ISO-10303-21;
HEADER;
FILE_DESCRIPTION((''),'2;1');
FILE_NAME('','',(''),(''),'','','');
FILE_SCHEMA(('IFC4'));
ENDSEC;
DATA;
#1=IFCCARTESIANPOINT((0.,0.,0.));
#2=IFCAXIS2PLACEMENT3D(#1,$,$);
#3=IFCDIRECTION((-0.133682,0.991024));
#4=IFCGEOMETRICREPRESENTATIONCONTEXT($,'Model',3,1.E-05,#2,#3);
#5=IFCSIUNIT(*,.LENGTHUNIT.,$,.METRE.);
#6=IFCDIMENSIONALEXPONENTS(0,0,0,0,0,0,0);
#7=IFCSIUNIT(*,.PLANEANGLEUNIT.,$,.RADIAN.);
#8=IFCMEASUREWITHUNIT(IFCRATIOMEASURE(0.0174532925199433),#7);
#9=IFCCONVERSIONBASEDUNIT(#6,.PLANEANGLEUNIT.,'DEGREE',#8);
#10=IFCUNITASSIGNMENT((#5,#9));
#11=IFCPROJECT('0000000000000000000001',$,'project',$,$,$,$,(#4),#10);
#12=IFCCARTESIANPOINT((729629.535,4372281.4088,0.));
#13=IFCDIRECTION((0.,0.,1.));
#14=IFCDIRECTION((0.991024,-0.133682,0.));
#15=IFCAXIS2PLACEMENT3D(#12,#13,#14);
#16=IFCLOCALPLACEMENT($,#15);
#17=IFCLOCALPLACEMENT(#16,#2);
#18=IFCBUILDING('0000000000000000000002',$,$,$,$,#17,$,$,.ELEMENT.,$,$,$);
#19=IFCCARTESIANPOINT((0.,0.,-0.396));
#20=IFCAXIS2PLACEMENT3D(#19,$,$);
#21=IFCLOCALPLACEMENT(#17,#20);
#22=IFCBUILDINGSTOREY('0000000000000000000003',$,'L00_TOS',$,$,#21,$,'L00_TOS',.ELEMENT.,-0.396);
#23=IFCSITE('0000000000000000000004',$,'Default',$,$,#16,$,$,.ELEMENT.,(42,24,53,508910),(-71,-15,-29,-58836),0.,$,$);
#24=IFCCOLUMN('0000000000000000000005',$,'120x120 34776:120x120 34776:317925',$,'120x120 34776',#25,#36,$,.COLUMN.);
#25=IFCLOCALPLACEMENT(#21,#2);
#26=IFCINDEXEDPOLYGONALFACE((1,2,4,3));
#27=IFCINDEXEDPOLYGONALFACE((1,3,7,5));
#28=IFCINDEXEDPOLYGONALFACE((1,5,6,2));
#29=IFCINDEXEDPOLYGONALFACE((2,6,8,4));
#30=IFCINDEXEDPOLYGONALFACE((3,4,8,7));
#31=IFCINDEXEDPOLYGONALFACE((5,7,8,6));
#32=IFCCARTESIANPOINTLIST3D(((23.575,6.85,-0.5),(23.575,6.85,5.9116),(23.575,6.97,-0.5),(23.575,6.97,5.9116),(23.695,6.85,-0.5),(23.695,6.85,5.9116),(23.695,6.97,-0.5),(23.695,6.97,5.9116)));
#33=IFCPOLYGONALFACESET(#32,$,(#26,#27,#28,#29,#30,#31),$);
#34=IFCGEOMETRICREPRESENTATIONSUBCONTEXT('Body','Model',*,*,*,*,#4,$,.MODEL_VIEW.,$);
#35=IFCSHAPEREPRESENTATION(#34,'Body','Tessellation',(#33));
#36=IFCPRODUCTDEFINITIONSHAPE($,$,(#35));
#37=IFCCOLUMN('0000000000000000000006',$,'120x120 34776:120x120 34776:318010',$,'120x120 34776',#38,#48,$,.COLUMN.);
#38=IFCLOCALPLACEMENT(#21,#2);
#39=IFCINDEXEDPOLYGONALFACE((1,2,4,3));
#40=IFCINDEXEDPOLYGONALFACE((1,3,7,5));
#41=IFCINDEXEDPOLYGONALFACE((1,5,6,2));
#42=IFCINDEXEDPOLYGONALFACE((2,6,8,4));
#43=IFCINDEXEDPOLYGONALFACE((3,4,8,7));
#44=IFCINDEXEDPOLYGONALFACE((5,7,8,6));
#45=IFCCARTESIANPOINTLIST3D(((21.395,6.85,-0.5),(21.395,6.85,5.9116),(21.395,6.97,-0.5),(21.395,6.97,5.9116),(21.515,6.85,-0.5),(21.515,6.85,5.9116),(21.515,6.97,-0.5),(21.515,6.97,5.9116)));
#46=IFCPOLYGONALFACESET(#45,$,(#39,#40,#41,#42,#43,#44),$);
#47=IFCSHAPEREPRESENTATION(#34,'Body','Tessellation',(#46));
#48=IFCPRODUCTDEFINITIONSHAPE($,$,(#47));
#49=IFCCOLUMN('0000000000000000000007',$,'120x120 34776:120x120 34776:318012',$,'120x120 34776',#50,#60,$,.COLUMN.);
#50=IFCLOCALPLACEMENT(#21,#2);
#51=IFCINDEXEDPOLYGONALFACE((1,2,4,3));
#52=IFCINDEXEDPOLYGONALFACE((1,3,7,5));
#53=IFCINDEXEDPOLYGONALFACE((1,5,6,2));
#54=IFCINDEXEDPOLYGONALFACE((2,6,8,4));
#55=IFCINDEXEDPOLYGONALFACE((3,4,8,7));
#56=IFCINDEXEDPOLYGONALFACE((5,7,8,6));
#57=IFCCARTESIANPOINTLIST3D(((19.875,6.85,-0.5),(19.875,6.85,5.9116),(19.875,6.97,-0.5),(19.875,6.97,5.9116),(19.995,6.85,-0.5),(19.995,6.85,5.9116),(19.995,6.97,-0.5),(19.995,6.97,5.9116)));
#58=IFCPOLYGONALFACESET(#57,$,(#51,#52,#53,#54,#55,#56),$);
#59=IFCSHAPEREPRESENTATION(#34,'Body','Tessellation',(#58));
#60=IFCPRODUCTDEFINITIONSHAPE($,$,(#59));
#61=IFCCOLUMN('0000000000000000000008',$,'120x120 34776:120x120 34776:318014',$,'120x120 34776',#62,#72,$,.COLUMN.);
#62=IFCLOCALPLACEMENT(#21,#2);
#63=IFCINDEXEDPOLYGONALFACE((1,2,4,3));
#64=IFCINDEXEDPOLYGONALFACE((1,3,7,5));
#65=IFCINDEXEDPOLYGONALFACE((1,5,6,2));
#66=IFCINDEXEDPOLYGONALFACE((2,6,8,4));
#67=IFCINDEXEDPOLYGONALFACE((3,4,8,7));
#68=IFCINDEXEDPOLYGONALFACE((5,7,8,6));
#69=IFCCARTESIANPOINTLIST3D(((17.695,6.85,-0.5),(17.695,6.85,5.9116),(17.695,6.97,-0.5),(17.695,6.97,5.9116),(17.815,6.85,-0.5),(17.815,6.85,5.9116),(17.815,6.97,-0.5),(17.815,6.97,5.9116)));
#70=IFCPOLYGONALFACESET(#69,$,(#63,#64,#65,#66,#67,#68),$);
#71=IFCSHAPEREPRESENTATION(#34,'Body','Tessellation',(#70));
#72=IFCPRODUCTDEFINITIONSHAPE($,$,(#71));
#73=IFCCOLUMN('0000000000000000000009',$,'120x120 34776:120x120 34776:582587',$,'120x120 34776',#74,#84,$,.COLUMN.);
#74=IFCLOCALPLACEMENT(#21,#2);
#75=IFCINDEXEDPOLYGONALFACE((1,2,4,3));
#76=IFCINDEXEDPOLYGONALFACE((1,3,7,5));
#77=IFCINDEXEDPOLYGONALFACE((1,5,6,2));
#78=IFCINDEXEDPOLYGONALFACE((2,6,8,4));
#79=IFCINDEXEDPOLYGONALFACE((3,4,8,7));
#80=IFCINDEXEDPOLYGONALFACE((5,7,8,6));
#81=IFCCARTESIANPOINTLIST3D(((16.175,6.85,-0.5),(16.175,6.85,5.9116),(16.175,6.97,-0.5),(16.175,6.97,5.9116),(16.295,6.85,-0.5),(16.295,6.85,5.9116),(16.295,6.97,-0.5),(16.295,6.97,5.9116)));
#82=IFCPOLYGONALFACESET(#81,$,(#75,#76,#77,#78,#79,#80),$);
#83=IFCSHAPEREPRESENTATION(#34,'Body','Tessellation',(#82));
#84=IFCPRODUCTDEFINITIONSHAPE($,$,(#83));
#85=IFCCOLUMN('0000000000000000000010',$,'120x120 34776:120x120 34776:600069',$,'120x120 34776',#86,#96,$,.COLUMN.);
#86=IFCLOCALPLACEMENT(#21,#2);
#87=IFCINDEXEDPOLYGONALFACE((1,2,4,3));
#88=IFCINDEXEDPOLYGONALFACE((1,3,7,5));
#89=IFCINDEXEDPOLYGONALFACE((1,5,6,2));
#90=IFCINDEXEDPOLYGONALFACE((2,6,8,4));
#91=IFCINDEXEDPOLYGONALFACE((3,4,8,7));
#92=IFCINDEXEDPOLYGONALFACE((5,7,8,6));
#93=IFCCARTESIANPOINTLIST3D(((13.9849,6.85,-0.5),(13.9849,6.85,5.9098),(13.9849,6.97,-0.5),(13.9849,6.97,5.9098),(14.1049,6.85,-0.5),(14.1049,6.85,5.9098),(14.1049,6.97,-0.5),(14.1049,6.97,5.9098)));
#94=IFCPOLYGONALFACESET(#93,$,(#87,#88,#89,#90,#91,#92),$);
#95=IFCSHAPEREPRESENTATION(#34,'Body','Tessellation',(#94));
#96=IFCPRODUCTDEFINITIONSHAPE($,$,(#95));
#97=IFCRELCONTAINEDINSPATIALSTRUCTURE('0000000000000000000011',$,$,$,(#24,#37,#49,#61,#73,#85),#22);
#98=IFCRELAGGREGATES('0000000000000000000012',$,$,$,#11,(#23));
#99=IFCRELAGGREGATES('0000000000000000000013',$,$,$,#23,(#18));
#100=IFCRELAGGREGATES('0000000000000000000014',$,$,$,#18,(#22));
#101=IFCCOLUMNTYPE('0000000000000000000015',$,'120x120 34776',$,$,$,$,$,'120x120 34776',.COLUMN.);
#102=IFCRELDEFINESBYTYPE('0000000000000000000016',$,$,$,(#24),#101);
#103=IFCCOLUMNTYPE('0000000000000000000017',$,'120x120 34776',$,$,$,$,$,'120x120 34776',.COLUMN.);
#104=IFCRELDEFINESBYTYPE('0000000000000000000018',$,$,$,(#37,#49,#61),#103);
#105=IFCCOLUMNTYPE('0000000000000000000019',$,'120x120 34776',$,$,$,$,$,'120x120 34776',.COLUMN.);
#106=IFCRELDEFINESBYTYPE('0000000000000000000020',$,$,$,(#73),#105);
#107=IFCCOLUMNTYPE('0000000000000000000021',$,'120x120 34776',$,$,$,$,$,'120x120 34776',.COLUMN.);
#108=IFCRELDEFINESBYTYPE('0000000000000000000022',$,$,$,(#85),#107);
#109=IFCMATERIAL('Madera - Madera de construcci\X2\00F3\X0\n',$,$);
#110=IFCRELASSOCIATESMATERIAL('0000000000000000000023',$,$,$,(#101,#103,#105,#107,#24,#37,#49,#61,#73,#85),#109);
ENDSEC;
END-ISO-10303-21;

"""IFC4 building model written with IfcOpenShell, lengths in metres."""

from ifc_helpers import new_model, entity, si_unit, converted_unit, direction, frame, origin, origin_2d_with_axis, place, context, subcontext, project, spatial, rectangle, extrude, source, transform, mapped, material, material_profile, profile_set, profile_usage, type_object, type_shapes, element, save


model = new_model("IFC4")

# Units and contexts
model_context = context("Model", 3, precision=1e-05, world=origin(), true_north=direction((-0.133682, 0.991024)))
body_context = subcontext(model_context, "Body", "Model", "MODEL_VIEW")
ifc_project = project(units=[si_unit("LENGTHUNIT", "METRE"), converted_unit("PLANEANGLEUNIT", "DEGREE", entity("IfcRatioMeasure", 0.0174532925199433), si_unit("PLANEANGLEUNIT", "RADIAN"), dimensions=[0, 0, 0, 0, 0, 0, 0])], contexts=[model_context])

# Site, building, storey
site_placement = place(None, frame((729629.535, 4372281.4088, 0.0), z_axis=(0.0, 0.0, 1.0), x_axis=(0.991024, -0.133682, 0.0)))
site = spatial("IfcSite", under=ifc_project, at=site_placement, Name="Default", CompositionType="ELEMENT", RefLatitude=(42, 24, 53, 508910), RefLongitude=(-71, -15, -29, -58836), RefElevation=0.0)
building_placement = place(site_placement, origin())
building = spatial("IfcBuilding", under=site, at=building_placement, CompositionType="ELEMENT")
storey_placement = place(building_placement, frame((0.0, 0.0, -0.396)))
storey = spatial("IfcBuildingStorey", under=building, at=storey_placement, Name="L00_TOS", LongName="L00_TOS", CompositionType="ELEMENT", Elevation=-0.396)

# Columns
ifc_material_1 = material(Name="Madera - Madera de construcción")
ifc_material_profile = material_profile(ifc_material_1, rectangle(XDim=0.12, YDim=0.12, at=origin_2d_with_axis()))
ifc_profile_set = profile_set([ifc_material_profile], Name="120x120 34776")
ifc_profile_usage_1 = profile_usage(ifc_profile_set)
column_type_1 = type_object("IfcColumnType", Name="120x120 34776", ElementType="120x120 34776", PredefinedType="COLUMN", material=ifc_profile_set)
shared_shape_1 = source(origin(), body_context, "Body", "SweptSolid", [
    extrude(rectangle(XDim=0.12, YDim=0.12, at=origin_2d_with_axis()), frame((23.635, 6.91, -0.896), z_axis=(0.0, 0.0, 1.0), x_axis=(0.0, -1.0, 0.0)), (0.0, 0.0, 1.0), 6.4116),
])
type_shapes(column_type_1, [shared_shape_1])
column_1_placement = place(storey_placement, frame((0.0, 0.0, 0.396)))
element("IfcColumn", 1, at=column_1_placement, inside=storey, type_object=column_type_1, material=ifc_profile_usage_1, Name="120x120 34776:120x120 34776:317925", ObjectType="120x120 34776", PredefinedType="COLUMN", context=body_context, shape_type="MappedRepresentation", body=[
    mapped(shared_shape_1, transform((0.0, 0.0, 0.0), scale=1.0)),
])
ifc_profile_usage_2 = profile_usage(ifc_profile_set)
column_type_2 = type_object("IfcColumnType", Name="120x120 34776", ElementType="120x120 34776", PredefinedType="COLUMN", material=ifc_profile_set)
shared_shape_2 = source(origin(), body_context, "Body", "SweptSolid", [
    extrude(rectangle(XDim=0.12, YDim=0.12, at=origin_2d_with_axis()), frame((0.0, 0.0, -0.896), z_axis=(0.0, 0.0, 1.0), x_axis=(0.0, -1.0, 0.0)), (0.0, 0.0, 1.0), 6.4116),
])
type_shapes(column_type_2, [shared_shape_2])
column_2_placement = place(storey_placement, frame((21.455, 6.91, 0.396)))
element("IfcColumn", 2, at=column_2_placement, inside=storey, type_object=column_type_2, material=ifc_profile_usage_2, Name="120x120 34776:120x120 34776:318010", ObjectType="120x120 34776", PredefinedType="COLUMN", context=body_context, shape_type="MappedRepresentation", body=[
    mapped(shared_shape_2, transform((0.0, 0.0, 0.0), scale=1.0)),
])
ifc_profile_usage_3 = profile_usage(ifc_profile_set)
column_3_placement = place(storey_placement, frame((19.935, 6.91, 0.396)))
element("IfcColumn", 3, at=column_3_placement, inside=storey, type_object=column_type_2, material=ifc_profile_usage_3, Name="120x120 34776:120x120 34776:318012", ObjectType="120x120 34776", PredefinedType="COLUMN", context=body_context, shape_type="MappedRepresentation", body=[
    mapped(shared_shape_2, transform((0.0, 0.0, 0.0), scale=1.0)),
])
ifc_profile_usage_4 = profile_usage(ifc_profile_set)
column_4_placement = place(storey_placement, frame((17.755, 6.91, 0.396)))
element("IfcColumn", 4, at=column_4_placement, inside=storey, type_object=column_type_2, material=ifc_profile_usage_4, Name="120x120 34776:120x120 34776:318014", ObjectType="120x120 34776", PredefinedType="COLUMN", context=body_context, shape_type="MappedRepresentation", body=[
    mapped(shared_shape_2, transform((0.0, 0.0, 0.0), scale=1.0)),
])
ifc_profile_usage_5 = profile_usage(ifc_profile_set)
column_type_3 = type_object("IfcColumnType", Name="120x120 34776", ElementType="120x120 34776", PredefinedType="COLUMN", material=ifc_profile_set)
shared_shape_3 = source(origin(), body_context, "Body", "SweptSolid", [
    extrude(rectangle(XDim=0.12, YDim=0.12, at=origin_2d_with_axis()), frame((16.235, 6.91, -0.896), z_axis=(0.0, 0.0, 1.0), x_axis=(0.0, -1.0, 0.0)), (0.0, 0.0, 1.0), 6.4116),
])
type_shapes(column_type_3, [shared_shape_3])
column_5_placement = place(storey_placement, frame((0.0, 0.0, 0.396)))
element("IfcColumn", 5, at=column_5_placement, inside=storey, type_object=column_type_3, material=ifc_profile_usage_5, Name="120x120 34776:120x120 34776:582587", ObjectType="120x120 34776", PredefinedType="COLUMN", context=body_context, shape_type="MappedRepresentation", body=[
    mapped(shared_shape_3, transform((0.0, 0.0, 0.0), scale=1.0)),
])
ifc_profile_usage_6 = profile_usage(ifc_profile_set)
column_type_4 = type_object("IfcColumnType", Name="120x120 34776", ElementType="120x120 34776", PredefinedType="COLUMN", material=ifc_profile_set)
shared_shape_4 = source(origin(), body_context, "Body", "SweptSolid", [
    extrude(rectangle(XDim=0.12, YDim=0.12, at=origin_2d_with_axis()), frame((14.0449, 6.91, -0.896), z_axis=(0.0, 0.0, 1.0), x_axis=(0.0, -1.0, 0.0)), (0.0, 0.0, 1.0), 6.4098),
])
type_shapes(column_type_4, [shared_shape_4])
column_6_placement = place(storey_placement, frame((0.0, 0.0, 0.396)))
element("IfcColumn", 6, at=column_6_placement, inside=storey, type_object=column_type_4, material=ifc_profile_usage_6, Name="120x120 34776:120x120 34776:600069", ObjectType="120x120 34776", PredefinedType="COLUMN", context=body_context, shape_type="MappedRepresentation", body=[
    mapped(shared_shape_4, transform((0.0, 0.0, 0.0), scale=1.0)),
])

save(model, "model.ifc")
